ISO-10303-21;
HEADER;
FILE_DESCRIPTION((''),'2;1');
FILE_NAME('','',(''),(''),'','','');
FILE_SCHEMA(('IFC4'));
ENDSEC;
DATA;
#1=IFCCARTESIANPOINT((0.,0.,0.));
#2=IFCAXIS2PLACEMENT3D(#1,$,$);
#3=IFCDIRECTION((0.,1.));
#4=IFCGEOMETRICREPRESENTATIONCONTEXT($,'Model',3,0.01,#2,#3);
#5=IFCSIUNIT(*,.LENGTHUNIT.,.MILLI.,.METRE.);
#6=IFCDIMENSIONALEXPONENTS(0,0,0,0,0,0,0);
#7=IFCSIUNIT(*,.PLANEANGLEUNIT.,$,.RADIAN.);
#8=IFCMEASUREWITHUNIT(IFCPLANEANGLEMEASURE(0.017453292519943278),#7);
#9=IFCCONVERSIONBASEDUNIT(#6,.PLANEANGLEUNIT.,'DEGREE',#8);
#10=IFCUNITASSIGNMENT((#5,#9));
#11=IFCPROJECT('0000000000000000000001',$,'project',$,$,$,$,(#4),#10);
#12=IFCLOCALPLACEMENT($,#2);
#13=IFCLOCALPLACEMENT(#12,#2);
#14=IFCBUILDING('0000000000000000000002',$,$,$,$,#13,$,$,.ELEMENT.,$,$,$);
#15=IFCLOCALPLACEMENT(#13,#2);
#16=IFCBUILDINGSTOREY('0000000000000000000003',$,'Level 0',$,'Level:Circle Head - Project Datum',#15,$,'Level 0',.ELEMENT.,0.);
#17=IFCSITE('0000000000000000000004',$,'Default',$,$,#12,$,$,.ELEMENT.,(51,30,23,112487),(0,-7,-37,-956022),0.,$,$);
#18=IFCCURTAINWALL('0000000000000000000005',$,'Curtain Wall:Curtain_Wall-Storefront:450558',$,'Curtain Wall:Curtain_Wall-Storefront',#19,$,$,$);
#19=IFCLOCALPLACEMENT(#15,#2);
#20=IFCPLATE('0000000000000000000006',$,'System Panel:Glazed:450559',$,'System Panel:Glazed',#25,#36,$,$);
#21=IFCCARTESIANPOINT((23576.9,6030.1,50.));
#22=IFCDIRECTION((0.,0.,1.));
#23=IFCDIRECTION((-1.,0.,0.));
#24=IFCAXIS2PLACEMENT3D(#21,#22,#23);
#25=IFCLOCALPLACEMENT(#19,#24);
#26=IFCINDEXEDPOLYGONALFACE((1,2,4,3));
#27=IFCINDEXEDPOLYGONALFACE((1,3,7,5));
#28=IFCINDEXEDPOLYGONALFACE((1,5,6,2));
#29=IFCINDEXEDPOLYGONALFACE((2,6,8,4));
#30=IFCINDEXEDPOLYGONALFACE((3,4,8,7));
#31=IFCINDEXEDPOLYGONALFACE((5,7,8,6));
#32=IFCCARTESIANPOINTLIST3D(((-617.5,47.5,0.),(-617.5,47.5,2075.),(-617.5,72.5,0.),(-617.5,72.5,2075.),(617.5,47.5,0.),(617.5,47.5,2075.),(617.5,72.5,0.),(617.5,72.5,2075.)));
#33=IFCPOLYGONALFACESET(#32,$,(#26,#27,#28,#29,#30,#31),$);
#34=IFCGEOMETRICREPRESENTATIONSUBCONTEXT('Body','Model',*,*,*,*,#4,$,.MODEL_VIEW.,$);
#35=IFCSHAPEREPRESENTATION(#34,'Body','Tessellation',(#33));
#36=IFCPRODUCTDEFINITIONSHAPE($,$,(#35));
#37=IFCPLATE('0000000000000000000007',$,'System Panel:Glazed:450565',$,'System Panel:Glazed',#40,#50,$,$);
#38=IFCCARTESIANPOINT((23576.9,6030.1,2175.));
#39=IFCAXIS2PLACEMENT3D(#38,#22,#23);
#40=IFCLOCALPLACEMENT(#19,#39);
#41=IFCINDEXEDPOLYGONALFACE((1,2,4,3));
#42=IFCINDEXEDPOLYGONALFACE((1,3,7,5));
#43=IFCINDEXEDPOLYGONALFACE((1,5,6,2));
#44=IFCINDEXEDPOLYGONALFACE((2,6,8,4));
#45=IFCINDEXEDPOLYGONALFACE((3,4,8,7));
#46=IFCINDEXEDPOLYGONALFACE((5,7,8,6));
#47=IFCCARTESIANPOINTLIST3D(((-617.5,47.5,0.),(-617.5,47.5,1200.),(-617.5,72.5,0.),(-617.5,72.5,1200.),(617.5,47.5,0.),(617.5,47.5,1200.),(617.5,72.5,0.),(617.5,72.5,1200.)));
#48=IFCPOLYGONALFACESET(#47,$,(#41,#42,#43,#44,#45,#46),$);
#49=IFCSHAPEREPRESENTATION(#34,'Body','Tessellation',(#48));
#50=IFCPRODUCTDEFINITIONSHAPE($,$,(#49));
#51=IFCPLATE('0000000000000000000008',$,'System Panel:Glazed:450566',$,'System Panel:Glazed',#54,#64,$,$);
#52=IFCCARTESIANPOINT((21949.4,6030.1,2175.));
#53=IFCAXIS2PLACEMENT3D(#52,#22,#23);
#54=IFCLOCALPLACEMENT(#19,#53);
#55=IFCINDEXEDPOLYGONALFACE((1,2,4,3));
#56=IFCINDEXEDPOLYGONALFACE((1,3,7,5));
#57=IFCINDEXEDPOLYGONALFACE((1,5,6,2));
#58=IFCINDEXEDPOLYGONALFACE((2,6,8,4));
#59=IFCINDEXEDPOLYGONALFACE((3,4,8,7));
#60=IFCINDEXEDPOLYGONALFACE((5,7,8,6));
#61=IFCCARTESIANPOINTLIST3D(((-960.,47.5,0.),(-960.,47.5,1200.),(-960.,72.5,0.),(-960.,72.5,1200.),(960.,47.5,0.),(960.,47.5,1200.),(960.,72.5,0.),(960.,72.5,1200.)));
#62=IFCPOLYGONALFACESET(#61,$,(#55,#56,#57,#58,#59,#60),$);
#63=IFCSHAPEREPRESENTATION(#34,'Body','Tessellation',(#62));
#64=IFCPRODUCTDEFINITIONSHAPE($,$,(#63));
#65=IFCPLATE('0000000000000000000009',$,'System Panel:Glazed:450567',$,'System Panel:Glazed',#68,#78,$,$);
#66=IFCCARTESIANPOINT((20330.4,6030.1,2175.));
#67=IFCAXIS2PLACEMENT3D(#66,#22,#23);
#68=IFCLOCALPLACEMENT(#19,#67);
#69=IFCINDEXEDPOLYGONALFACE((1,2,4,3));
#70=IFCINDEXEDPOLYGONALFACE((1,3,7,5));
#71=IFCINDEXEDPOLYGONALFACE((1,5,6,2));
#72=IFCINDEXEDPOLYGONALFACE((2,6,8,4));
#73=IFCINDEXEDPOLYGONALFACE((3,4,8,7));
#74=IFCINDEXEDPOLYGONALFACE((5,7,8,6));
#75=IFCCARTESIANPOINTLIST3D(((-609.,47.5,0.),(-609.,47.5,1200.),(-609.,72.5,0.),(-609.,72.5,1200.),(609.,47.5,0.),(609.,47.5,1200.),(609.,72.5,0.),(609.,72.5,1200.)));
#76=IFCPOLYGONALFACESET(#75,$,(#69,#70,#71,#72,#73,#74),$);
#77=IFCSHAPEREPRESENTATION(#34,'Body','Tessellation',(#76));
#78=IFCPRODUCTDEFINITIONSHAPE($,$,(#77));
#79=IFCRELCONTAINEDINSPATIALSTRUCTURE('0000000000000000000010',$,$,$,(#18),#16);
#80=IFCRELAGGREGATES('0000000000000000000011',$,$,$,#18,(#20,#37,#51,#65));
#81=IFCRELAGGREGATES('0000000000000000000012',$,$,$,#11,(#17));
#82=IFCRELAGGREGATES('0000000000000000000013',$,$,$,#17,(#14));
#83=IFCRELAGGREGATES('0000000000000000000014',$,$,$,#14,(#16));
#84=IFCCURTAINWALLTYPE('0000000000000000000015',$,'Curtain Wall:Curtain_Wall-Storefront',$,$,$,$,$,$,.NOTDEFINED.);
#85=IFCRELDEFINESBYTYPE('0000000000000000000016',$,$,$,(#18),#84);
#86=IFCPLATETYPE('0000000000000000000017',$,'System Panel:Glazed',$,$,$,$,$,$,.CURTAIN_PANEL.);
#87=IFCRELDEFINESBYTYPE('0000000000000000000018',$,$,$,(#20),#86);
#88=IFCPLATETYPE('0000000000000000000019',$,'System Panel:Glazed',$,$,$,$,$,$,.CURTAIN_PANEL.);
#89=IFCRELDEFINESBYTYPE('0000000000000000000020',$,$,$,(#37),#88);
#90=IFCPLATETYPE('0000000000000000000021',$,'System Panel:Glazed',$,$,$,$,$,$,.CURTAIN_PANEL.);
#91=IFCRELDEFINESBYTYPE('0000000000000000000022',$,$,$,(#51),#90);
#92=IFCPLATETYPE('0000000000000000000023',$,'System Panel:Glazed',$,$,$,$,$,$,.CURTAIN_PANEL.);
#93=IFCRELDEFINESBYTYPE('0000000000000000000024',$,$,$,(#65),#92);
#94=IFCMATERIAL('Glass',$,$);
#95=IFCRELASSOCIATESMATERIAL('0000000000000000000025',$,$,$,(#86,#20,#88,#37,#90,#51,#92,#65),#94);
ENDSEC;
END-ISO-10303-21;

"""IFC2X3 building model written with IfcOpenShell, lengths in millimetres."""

from ifc_helpers import new_model, entity, si_unit, converted_unit, direction, frame, origin, origin_2d_with_axis, place, context, subcontext, project, spatial, rectangle, extrude, source, transform, mapped, material, type_object, type_shapes, element, aggregate, save


model = new_model("IFC2X3")

# Units and contexts
model_context = context("Model", 3, precision=0.01, world=origin(), true_north=direction((0.0, 1.0)))
body_context = subcontext(model_context, "Body", "Model", "MODEL_VIEW")
ifc_project = project(units=[si_unit("LENGTHUNIT", "METRE", prefix="MILLI"), converted_unit("PLANEANGLEUNIT", "DEGREE", entity("IfcPlaneAngleMeasure", 0.017453292519943278), si_unit("PLANEANGLEUNIT", "RADIAN"), dimensions=[0, 0, 0, 0, 0, 0, 0])], contexts=[model_context])

# Site, building, storey
site_placement = place(None, origin())
site = spatial("IfcSite", under=ifc_project, at=site_placement, Name="Default", CompositionType="ELEMENT", RefLatitude=(51, 30, 23, 112487), RefLongitude=(0, -7, -37, -956022), RefElevation=0.0)
building_placement = place(site_placement, origin())
building = spatial("IfcBuilding", under=site, at=building_placement, CompositionType="ELEMENT")
storey_placement = place(building_placement, origin())
storey = spatial("IfcBuildingStorey", under=building, at=storey_placement, Name="Level 0", ObjectType="Level:Circle Head - Project Datum", LongName="Level 0", CompositionType="ELEMENT", Elevation=0.0)

# Curtain wall, plates
curtain_wall_type = type_object("IfcCurtainWallType", Name="Curtain Wall:Curtain_Wall-Storefront", PredefinedType="NOTDEFINED")
curtain_wall_placement = place(storey_placement, origin())
curtain_wall = element("IfcCurtainWall", 1, at=curtain_wall_placement, inside=storey, type_object=curtain_wall_type, Name="Curtain Wall:Curtain_Wall-Storefront:450558", ObjectType="Curtain Wall:Curtain_Wall-Storefront")
ifc_material_1 = material(Name="Glass")
plate_type_1 = type_object("IfcPlateType", Name="System Panel:Glazed", PredefinedType="CURTAIN_PANEL", material=ifc_material_1)
shared_shape_1 = source(origin(), body_context, "Body", "SweptSolid", [
    extrude(rectangle(XDim=25.0, YDim=1235.0, at=origin_2d_with_axis()), frame((0.0, 60.0, 0.0), z_axis=(0.0, 0.0, 1.0), x_axis=(0.0, 1.0, 0.0)), (0.0, 0.0, 1.0), 2075.0),
])
type_shapes(plate_type_1, [shared_shape_1])
plate_1_placement = place(curtain_wall_placement, frame((23576.9, 6030.1, 50.0), z_axis=(0.0, 0.0, 1.0), x_axis=(-1.0, 0.0, 0.0)))
plate_1 = element("IfcPlate", 2, at=plate_1_placement, type_object=plate_type_1, material=ifc_material_1, Name="System Panel:Glazed:450559", ObjectType="System Panel:Glazed", context=body_context, shape_type="MappedRepresentation", body=[
    mapped(shared_shape_1, transform((0.0, 0.0, 0.0), scale=1.0)),
])
plate_type_2 = type_object("IfcPlateType", Name="System Panel:Glazed", PredefinedType="CURTAIN_PANEL", material=ifc_material_1)
shared_shape_2 = source(origin(), body_context, "Body", "SweptSolid", [
    extrude(rectangle(XDim=25.0, YDim=1235.0, at=origin_2d_with_axis()), frame((0.0, 60.0, 0.0), z_axis=(0.0, 0.0, 1.0), x_axis=(0.0, 1.0, 0.0)), (0.0, 0.0, 1.0), 1200.0),
])
type_shapes(plate_type_2, [shared_shape_2])
plate_2_placement = place(curtain_wall_placement, frame((23576.9, 6030.1, 2175.0), z_axis=(0.0, 0.0, 1.0), x_axis=(-1.0, 0.0, 0.0)))
plate_2 = element("IfcPlate", 3, at=plate_2_placement, type_object=plate_type_2, material=ifc_material_1, Name="System Panel:Glazed:450565", ObjectType="System Panel:Glazed", context=body_context, shape_type="MappedRepresentation", body=[
    mapped(shared_shape_2, transform((0.0, 0.0, 0.0), scale=1.0)),
])
plate_type_3 = type_object("IfcPlateType", Name="System Panel:Glazed", PredefinedType="CURTAIN_PANEL", material=ifc_material_1)
shared_shape_3 = source(origin(), body_context, "Body", "SweptSolid", [
    extrude(rectangle(XDim=25.0, YDim=1920.0, at=origin_2d_with_axis()), frame((0.0, 60.0, 0.0), z_axis=(0.0, 0.0, 1.0), x_axis=(0.0, 1.0, 0.0)), (0.0, 0.0, 1.0), 1200.0),
])
type_shapes(plate_type_3, [shared_shape_3])
plate_3_placement = place(curtain_wall_placement, frame((21949.4, 6030.1, 2175.0), z_axis=(0.0, 0.0, 1.0), x_axis=(-1.0, 0.0, 0.0)))
plate_3 = element("IfcPlate", 4, at=plate_3_placement, type_object=plate_type_3, material=ifc_material_1, Name="System Panel:Glazed:450566", ObjectType="System Panel:Glazed", context=body_context, shape_type="MappedRepresentation", body=[
    mapped(shared_shape_3, transform((0.0, 0.0, 0.0), scale=1.0)),
])
plate_type_4 = type_object("IfcPlateType", Name="System Panel:Glazed", PredefinedType="CURTAIN_PANEL", material=ifc_material_1)
shared_shape_4 = source(origin(), body_context, "Body", "SweptSolid", [
    extrude(rectangle(XDim=25.0, YDim=1218.0, at=origin_2d_with_axis()), frame((0.0, 60.0, 0.0), z_axis=(0.0, 0.0, 1.0), x_axis=(0.0, 1.0, 0.0)), (0.0, 0.0, 1.0), 1200.0),
])
type_shapes(plate_type_4, [shared_shape_4])
plate_4_placement = place(curtain_wall_placement, frame((20330.4, 6030.1, 2175.0), z_axis=(0.0, 0.0, 1.0), x_axis=(-1.0, 0.0, 0.0)))
plate_4 = element("IfcPlate", 5, at=plate_4_placement, type_object=plate_type_4, material=ifc_material_1, Name="System Panel:Glazed:450567", ObjectType="System Panel:Glazed", context=body_context, shape_type="MappedRepresentation", body=[
    mapped(shared_shape_4, transform((0.0, 0.0, 0.0), scale=1.0)),
])
aggregate(curtain_wall, [plate_1, plate_2, plate_3, plate_4])

save(model, "model.ifc")
